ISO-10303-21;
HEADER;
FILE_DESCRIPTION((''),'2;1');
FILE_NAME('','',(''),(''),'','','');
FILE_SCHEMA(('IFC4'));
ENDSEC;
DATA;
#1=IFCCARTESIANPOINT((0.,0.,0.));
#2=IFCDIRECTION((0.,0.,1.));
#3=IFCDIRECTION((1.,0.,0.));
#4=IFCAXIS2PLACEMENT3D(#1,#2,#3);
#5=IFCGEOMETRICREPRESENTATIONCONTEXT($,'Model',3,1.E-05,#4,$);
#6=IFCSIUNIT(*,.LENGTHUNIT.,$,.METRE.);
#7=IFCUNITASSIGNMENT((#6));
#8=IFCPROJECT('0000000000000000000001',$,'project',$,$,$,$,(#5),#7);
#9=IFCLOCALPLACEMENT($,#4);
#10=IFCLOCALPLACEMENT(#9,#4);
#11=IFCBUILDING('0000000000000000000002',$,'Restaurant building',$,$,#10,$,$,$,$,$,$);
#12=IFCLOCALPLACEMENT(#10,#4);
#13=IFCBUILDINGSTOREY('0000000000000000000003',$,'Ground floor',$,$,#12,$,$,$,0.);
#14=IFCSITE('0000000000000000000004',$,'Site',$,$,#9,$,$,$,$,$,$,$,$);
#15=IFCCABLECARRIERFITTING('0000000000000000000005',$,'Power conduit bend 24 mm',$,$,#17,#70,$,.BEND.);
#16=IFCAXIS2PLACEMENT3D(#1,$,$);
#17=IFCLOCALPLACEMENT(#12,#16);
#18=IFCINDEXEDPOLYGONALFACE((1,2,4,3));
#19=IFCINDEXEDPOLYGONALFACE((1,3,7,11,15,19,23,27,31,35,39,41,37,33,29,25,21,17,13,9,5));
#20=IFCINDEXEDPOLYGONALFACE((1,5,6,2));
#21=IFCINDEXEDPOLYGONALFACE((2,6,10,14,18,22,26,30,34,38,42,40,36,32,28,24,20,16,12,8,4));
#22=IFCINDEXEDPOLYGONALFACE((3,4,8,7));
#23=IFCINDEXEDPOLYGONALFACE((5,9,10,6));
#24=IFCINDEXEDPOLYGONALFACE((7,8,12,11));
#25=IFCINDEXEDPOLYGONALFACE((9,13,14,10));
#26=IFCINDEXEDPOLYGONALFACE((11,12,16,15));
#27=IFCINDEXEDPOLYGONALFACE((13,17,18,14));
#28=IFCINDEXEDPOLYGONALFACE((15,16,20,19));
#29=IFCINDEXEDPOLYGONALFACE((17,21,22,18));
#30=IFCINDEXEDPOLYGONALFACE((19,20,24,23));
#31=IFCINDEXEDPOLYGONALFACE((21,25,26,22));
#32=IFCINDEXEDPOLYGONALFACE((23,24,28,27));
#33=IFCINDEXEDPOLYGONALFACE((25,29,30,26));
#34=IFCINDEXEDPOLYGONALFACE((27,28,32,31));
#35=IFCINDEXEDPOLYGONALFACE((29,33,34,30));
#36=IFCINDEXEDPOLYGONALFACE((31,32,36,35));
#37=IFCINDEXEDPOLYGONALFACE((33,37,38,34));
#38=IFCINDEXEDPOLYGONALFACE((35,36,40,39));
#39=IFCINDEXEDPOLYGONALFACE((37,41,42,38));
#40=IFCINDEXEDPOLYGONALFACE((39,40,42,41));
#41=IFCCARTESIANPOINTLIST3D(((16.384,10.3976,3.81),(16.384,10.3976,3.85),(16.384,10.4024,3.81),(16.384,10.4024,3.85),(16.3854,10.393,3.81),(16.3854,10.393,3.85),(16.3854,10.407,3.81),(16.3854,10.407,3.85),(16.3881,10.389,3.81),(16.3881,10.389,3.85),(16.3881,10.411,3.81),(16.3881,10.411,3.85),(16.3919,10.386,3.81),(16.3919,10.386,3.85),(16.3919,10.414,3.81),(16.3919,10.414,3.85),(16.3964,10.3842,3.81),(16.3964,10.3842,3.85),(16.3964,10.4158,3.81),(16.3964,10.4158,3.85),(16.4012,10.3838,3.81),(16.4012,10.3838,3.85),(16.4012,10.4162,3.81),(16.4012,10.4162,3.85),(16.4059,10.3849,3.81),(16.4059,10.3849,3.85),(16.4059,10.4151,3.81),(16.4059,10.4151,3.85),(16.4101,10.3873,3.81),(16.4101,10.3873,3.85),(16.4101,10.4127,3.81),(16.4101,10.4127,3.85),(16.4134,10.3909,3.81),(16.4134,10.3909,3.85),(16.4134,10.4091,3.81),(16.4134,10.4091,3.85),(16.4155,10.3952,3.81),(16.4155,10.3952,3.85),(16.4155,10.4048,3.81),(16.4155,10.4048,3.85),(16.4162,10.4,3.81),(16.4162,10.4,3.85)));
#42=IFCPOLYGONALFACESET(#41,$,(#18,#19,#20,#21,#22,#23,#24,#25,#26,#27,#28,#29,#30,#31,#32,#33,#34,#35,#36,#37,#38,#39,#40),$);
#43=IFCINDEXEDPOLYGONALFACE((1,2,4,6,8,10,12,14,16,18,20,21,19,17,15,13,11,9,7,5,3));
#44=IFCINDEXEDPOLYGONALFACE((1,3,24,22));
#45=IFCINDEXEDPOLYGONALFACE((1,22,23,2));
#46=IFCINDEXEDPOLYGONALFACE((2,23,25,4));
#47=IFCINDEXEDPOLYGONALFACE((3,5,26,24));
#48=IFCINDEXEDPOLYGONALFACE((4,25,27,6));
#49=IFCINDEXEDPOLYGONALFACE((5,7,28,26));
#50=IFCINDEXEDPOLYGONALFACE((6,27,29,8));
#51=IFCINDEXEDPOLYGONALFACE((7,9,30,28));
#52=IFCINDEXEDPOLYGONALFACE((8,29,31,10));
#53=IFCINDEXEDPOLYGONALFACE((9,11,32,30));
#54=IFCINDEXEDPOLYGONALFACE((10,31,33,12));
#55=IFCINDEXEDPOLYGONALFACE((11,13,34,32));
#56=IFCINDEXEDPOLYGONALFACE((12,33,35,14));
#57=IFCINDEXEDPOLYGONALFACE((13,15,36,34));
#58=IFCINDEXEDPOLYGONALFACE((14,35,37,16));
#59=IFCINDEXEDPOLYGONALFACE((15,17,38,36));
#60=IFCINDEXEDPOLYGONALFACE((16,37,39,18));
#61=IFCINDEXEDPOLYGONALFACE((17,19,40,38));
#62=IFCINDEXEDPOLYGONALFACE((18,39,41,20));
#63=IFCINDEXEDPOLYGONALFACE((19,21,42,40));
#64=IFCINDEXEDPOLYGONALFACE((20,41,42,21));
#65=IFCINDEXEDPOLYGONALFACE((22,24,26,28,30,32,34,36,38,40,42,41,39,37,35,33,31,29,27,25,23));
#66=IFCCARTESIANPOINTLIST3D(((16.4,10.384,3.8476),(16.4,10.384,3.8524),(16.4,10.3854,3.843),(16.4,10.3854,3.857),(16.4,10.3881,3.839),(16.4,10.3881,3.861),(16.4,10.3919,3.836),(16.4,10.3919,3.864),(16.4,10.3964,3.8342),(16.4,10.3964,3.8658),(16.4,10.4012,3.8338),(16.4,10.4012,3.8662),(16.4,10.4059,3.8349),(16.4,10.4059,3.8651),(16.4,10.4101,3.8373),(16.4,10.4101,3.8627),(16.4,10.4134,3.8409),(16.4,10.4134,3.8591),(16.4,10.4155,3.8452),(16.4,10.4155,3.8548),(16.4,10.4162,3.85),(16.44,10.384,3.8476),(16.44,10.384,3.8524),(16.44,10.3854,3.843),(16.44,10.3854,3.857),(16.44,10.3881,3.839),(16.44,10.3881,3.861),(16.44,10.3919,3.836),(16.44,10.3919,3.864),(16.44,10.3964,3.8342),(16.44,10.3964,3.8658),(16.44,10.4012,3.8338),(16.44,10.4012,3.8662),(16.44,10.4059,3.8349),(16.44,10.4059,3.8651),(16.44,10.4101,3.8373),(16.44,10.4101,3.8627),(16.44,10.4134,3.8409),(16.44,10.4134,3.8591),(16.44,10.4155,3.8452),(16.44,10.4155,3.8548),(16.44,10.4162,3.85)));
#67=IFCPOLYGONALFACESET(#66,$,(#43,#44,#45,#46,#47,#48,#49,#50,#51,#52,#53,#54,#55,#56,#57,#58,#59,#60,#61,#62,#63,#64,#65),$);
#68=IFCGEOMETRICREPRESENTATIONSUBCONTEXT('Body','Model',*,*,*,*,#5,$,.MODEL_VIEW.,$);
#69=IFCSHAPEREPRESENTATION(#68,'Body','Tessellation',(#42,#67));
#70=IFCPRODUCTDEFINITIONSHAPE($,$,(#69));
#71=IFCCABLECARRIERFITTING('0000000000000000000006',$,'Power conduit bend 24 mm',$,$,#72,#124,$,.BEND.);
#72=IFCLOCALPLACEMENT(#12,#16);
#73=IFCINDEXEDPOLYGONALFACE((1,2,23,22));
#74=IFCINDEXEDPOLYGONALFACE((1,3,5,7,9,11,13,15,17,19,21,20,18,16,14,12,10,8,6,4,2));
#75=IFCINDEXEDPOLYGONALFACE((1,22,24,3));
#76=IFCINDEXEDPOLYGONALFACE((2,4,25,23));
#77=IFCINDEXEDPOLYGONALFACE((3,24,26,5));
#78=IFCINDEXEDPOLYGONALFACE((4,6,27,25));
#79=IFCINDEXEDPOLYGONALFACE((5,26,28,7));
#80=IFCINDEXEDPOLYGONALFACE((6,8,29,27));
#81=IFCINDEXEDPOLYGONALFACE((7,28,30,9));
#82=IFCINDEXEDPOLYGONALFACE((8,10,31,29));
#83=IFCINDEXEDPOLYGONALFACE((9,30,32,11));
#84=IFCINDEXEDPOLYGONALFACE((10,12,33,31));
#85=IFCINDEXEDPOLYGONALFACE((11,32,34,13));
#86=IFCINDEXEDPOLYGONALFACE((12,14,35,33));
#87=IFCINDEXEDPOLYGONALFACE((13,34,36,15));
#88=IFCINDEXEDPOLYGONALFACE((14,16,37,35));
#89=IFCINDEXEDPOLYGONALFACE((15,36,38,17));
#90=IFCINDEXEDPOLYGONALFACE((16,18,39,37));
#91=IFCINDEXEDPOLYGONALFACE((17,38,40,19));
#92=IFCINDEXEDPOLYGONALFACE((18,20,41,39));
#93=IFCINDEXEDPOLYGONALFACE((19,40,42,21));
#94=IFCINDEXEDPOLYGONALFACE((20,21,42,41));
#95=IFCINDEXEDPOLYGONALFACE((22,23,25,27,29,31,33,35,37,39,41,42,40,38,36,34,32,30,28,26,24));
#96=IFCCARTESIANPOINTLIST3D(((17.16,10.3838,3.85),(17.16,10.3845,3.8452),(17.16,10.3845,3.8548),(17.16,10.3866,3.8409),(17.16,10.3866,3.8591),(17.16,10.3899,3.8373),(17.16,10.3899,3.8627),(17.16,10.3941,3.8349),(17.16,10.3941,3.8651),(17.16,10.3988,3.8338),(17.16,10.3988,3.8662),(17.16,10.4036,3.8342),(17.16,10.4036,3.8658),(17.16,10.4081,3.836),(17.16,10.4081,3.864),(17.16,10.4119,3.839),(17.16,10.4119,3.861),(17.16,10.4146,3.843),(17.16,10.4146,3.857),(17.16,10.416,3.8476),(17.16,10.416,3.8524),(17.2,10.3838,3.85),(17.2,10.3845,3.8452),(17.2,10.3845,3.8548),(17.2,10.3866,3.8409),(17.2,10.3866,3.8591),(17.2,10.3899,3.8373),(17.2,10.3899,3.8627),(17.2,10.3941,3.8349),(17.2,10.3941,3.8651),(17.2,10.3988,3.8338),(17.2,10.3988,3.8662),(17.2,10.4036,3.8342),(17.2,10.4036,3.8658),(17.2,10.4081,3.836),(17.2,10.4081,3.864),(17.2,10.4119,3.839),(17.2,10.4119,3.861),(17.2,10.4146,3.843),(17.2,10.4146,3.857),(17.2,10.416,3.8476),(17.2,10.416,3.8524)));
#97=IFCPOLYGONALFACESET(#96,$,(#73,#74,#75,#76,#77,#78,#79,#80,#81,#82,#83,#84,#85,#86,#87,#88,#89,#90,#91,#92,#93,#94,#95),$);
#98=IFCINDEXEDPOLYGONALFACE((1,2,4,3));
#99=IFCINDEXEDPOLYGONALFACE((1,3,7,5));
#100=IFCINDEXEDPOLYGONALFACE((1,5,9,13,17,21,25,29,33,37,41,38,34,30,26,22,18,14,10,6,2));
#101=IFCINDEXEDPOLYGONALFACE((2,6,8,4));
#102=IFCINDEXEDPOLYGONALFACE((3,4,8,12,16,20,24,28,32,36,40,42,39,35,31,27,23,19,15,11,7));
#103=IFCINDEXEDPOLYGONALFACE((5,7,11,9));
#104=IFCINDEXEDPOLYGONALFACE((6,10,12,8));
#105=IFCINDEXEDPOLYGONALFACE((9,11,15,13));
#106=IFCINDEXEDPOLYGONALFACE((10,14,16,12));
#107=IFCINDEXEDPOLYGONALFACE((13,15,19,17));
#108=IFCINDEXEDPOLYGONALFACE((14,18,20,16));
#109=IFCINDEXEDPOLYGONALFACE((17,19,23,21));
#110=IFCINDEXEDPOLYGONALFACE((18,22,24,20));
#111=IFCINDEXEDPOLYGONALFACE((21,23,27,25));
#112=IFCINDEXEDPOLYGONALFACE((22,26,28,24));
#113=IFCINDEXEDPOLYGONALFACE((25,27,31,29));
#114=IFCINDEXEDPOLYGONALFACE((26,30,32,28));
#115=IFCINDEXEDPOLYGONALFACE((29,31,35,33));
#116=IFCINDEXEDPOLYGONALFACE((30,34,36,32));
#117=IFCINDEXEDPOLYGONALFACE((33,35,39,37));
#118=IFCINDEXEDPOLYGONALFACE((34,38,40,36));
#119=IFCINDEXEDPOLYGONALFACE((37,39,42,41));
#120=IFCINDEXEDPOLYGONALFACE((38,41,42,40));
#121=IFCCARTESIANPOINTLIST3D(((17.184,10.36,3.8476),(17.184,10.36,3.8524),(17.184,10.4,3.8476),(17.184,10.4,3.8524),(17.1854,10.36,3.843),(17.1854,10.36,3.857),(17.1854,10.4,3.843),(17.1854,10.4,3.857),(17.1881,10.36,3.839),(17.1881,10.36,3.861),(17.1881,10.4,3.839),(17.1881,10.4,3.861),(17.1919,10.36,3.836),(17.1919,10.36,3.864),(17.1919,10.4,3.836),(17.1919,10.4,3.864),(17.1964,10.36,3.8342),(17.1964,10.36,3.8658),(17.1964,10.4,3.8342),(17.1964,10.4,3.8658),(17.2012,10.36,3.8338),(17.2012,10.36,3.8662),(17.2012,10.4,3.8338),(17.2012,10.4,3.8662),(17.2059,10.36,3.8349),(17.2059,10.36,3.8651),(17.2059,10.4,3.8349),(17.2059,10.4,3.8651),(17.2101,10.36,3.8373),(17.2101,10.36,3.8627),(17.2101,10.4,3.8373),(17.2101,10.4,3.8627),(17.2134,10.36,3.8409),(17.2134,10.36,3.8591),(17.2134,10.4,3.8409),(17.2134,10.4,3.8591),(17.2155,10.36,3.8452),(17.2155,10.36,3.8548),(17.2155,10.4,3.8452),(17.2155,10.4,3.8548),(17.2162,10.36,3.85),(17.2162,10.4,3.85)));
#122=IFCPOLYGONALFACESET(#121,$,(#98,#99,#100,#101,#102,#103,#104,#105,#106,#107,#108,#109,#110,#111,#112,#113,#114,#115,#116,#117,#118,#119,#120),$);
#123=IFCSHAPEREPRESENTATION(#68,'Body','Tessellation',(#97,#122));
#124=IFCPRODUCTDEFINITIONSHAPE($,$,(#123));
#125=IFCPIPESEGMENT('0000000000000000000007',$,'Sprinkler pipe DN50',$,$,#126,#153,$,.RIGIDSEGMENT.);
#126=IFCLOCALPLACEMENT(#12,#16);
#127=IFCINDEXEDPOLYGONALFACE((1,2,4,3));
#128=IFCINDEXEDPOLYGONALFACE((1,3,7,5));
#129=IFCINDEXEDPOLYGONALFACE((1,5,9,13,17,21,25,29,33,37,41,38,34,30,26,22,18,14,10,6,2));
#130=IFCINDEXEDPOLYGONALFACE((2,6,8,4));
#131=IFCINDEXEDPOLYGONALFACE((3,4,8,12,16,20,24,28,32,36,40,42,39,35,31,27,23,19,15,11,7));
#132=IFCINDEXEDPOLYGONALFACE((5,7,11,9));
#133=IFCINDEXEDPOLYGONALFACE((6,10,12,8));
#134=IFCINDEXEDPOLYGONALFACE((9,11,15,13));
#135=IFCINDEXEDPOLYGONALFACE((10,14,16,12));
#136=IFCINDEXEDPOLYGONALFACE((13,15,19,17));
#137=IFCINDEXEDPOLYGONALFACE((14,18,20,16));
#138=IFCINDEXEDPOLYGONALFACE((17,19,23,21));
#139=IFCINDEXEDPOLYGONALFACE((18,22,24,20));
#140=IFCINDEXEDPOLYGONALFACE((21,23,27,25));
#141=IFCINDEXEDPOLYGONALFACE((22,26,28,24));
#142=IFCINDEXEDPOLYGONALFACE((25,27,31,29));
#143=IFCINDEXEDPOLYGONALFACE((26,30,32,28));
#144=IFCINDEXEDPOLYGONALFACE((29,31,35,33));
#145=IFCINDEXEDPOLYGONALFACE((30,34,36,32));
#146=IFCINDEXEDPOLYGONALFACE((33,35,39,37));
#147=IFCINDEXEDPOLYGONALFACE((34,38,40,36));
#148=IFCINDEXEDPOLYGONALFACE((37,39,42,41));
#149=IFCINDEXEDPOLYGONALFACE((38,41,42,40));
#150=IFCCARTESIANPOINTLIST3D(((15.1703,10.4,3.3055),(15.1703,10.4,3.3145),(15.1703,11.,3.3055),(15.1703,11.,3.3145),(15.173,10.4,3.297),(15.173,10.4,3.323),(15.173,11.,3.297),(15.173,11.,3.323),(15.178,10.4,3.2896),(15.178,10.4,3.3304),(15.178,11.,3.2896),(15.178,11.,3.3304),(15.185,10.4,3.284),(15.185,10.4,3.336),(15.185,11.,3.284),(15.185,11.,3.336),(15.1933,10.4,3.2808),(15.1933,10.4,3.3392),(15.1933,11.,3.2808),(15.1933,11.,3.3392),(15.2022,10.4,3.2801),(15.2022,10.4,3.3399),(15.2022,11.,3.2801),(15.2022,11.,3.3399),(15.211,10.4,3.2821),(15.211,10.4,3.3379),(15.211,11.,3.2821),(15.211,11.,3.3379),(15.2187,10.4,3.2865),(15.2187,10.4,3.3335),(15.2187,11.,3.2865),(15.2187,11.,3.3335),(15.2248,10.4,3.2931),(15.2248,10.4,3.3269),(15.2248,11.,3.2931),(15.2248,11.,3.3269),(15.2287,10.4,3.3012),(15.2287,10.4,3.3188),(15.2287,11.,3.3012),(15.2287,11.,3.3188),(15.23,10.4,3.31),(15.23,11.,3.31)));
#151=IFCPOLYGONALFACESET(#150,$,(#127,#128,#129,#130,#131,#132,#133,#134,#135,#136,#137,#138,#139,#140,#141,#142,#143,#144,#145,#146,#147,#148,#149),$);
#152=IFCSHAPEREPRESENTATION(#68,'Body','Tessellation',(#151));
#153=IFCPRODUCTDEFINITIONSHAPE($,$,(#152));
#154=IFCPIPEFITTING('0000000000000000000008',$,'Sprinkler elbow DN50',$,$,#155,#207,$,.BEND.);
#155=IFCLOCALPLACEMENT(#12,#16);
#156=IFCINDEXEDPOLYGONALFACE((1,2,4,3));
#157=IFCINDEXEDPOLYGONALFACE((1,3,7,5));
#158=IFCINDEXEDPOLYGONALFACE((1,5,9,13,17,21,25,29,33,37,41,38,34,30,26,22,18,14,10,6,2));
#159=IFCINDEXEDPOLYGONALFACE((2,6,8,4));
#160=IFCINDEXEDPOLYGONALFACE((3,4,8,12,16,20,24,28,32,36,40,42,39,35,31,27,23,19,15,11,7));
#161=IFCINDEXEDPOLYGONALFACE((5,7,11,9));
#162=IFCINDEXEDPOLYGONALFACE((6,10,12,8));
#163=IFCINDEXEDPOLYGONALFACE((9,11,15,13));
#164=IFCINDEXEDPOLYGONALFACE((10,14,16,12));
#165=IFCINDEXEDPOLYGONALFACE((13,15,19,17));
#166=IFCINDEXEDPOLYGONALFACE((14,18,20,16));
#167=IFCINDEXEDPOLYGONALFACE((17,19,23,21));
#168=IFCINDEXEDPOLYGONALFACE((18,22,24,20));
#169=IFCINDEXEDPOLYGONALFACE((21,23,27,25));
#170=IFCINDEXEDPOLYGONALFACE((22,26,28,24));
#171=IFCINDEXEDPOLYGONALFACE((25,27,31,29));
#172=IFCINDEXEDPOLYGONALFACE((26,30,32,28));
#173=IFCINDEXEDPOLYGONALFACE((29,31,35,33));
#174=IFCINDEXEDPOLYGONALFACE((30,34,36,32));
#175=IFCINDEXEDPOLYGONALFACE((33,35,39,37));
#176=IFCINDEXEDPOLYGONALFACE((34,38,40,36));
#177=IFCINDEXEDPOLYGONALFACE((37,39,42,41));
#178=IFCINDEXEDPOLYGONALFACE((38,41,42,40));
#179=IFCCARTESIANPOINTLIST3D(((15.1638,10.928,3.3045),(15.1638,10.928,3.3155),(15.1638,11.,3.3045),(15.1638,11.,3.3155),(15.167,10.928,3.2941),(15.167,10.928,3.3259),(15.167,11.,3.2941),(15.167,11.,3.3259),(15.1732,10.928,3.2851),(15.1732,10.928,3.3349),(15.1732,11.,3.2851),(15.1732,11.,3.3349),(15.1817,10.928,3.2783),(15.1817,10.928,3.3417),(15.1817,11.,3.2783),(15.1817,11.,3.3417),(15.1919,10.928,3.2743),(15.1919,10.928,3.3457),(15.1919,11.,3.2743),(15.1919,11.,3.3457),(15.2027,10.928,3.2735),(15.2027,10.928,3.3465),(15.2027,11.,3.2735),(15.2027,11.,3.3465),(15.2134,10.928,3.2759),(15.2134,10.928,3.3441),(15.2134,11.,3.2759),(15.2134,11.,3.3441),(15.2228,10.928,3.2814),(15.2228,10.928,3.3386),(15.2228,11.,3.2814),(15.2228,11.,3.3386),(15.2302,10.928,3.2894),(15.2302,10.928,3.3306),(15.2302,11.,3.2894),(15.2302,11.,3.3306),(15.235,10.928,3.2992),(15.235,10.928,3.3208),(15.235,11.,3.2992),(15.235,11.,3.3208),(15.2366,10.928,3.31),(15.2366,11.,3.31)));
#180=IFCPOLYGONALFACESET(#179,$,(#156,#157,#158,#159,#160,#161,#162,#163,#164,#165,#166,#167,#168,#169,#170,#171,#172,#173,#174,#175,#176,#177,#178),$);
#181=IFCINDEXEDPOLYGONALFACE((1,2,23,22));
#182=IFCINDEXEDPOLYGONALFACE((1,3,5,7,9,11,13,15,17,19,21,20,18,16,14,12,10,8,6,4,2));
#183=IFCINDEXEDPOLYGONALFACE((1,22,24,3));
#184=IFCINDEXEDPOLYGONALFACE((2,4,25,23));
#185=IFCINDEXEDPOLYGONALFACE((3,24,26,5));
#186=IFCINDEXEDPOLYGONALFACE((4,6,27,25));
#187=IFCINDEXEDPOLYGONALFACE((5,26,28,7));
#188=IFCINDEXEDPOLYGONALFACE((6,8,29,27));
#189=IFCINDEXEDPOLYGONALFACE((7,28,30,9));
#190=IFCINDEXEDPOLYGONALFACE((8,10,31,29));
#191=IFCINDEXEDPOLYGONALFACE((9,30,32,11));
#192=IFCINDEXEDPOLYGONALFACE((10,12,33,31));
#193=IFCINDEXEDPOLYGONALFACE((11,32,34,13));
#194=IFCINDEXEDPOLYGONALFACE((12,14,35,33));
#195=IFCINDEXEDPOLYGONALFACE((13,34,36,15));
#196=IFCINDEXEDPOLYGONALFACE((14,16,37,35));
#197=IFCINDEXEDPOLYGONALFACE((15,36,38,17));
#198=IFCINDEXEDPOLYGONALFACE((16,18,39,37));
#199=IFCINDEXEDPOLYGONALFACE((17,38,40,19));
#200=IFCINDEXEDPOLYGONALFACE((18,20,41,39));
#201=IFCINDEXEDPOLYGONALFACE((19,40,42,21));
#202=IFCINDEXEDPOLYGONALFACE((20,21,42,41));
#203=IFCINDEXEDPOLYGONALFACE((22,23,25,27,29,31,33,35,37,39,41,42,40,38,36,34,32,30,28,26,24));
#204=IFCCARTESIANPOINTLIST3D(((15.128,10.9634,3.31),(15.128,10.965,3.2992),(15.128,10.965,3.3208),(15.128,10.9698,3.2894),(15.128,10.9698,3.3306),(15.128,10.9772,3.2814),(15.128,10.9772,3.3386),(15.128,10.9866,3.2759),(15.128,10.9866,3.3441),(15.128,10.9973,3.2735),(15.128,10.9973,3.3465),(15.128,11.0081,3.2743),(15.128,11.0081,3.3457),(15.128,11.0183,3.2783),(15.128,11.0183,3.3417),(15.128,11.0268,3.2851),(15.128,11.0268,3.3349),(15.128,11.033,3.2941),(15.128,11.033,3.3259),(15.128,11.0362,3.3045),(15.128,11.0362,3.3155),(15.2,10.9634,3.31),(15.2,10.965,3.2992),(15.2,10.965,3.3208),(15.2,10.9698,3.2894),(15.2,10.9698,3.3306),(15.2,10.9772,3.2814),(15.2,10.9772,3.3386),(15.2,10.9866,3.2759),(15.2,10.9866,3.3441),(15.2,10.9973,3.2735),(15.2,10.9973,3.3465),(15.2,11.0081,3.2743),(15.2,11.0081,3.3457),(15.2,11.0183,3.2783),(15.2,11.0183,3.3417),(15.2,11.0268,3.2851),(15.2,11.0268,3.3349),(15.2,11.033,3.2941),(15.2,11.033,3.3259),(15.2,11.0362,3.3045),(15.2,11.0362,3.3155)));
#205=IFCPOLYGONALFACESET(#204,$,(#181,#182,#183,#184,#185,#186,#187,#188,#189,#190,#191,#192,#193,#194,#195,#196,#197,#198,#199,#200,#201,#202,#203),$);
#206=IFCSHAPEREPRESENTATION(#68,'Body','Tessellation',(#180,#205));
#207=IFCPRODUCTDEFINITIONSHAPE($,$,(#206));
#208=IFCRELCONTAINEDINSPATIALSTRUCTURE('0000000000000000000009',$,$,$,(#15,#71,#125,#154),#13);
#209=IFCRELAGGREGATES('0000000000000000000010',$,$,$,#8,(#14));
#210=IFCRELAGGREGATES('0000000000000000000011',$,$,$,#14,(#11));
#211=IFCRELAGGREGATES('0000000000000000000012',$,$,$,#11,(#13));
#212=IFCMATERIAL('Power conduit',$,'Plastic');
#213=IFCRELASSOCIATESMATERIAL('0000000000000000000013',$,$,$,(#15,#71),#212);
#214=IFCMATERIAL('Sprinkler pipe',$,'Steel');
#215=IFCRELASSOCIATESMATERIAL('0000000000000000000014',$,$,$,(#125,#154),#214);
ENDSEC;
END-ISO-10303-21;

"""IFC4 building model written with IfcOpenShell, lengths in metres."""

from ifc_helpers import new_model, si_unit, frame, origin_with_axes, origin_2d, place, context, subcontext, project, spatial, circle, extrude, material, element, save


model = new_model("IFC4")

# Units and contexts
model_context = context("Model", 3, precision=1e-05, world=origin_with_axes())
body_context = subcontext(model_context, "Body", "Model", "MODEL_VIEW")
ifc_project = project(units=[si_unit("LENGTHUNIT", "METRE")], contexts=[model_context])

# Site, building, storey
site_placement = place(None, origin_with_axes())
site = spatial("IfcSite", under=ifc_project, at=site_placement, Name="Site")
building_placement = place(site_placement, origin_with_axes())
building = spatial("IfcBuilding", under=site, at=building_placement, Name="Restaurant building")
storey_placement = place(building_placement, origin_with_axes())
storey = spatial("IfcBuildingStorey", under=building, at=storey_placement, Name="Ground floor", Elevation=0.0)

# Shared definitions
ifc_material_1 = material(Name="Power conduit", Category="Plastic")

# Cable carrier fittings
cable_carrier_fitting_1_placement = place(storey_placement, frame((16.4, 10.4, 3.85)))
element("IfcCableCarrierFitting", 1, at=cable_carrier_fitting_1_placement, inside=storey, material=ifc_material_1, Name="Power conduit bend 24 mm", PredefinedType="BEND", context=body_context, shape_type="SweptSolid", body=[
    extrude(circle(Radius=0.0162, at=origin_2d()), frame((0.0, 0.0, 0.0), z_axis=(0.0, 0.0, -1.0), x_axis=(1.0, 0.0, 0.0)), (0.0, 0.0, 1.0), 0.04),
    extrude(circle(Radius=0.0162, at=origin_2d()), frame((0.0, 0.0, 0.0), z_axis=(1.0, 0.0, 0.0), x_axis=(0.0, 1.0, 0.0)), (0.0, 0.0, 1.0), 0.04),
])
cable_carrier_fitting_2_placement = place(storey_placement, frame((17.2, 10.4, 3.85)))
element("IfcCableCarrierFitting", 2, at=cable_carrier_fitting_2_placement, inside=storey, material=ifc_material_1, Name="Power conduit bend 24 mm", PredefinedType="BEND", context=body_context, shape_type="SweptSolid", body=[
    extrude(circle(Radius=0.0162, at=origin_2d()), frame((0.0, 0.0, 0.0), z_axis=(-1.0, 0.0, 0.0), x_axis=(0.0, -1.0, 0.0)), (0.0, 0.0, 1.0), 0.04),
    extrude(circle(Radius=0.0162, at=origin_2d()), frame((0.0, 0.0, 0.0), z_axis=(0.0, -1.0, 0.0), x_axis=(1.0, 0.0, 0.0)), (0.0, 0.0, 1.0), 0.04),
])

# Pipe segment
ifc_material_2 = material(Name="Sprinkler pipe", Category="Steel")
pipe_segment_placement = place(storey_placement, frame((15.2, 11.0, 3.31)))
element("IfcPipeSegment", 3, at=pipe_segment_placement, inside=storey, material=ifc_material_2, Name="Sprinkler pipe DN50", PredefinedType="RIGIDSEGMENT", context=body_context, shape_type="SweptSolid", body=[
    extrude(circle(Radius=0.03, at=origin_2d()), frame((0.0, 0.0, 0.0), z_axis=(0.0, -1.0, 0.0), x_axis=(1.0, 0.0, 0.0)), (0.0, 0.0, 1.0), 0.6),
])

# Pipe fitting
pipe_fitting_placement = place(storey_placement, frame((15.2, 11.0, 3.31)))
element("IfcPipeFitting", 4, at=pipe_fitting_placement, inside=storey, material=ifc_material_2, Name="Sprinkler elbow DN50", PredefinedType="BEND", context=body_context, shape_type="SweptSolid", body=[
    extrude(circle(Radius=0.0366, at=origin_2d()), frame((0.0, 0.0, 0.0), z_axis=(0.0, -1.0, 0.0), x_axis=(1.0, 0.0, 0.0)), (0.0, 0.0, 1.0), 0.072),
    extrude(circle(Radius=0.0366, at=origin_2d()), frame((0.0, 0.0, 0.0), z_axis=(-1.0, 0.0, 0.0), x_axis=(0.0, -1.0, 0.0)), (0.0, 0.0, 1.0), 0.072),
])

save(model, "model.ifc")
